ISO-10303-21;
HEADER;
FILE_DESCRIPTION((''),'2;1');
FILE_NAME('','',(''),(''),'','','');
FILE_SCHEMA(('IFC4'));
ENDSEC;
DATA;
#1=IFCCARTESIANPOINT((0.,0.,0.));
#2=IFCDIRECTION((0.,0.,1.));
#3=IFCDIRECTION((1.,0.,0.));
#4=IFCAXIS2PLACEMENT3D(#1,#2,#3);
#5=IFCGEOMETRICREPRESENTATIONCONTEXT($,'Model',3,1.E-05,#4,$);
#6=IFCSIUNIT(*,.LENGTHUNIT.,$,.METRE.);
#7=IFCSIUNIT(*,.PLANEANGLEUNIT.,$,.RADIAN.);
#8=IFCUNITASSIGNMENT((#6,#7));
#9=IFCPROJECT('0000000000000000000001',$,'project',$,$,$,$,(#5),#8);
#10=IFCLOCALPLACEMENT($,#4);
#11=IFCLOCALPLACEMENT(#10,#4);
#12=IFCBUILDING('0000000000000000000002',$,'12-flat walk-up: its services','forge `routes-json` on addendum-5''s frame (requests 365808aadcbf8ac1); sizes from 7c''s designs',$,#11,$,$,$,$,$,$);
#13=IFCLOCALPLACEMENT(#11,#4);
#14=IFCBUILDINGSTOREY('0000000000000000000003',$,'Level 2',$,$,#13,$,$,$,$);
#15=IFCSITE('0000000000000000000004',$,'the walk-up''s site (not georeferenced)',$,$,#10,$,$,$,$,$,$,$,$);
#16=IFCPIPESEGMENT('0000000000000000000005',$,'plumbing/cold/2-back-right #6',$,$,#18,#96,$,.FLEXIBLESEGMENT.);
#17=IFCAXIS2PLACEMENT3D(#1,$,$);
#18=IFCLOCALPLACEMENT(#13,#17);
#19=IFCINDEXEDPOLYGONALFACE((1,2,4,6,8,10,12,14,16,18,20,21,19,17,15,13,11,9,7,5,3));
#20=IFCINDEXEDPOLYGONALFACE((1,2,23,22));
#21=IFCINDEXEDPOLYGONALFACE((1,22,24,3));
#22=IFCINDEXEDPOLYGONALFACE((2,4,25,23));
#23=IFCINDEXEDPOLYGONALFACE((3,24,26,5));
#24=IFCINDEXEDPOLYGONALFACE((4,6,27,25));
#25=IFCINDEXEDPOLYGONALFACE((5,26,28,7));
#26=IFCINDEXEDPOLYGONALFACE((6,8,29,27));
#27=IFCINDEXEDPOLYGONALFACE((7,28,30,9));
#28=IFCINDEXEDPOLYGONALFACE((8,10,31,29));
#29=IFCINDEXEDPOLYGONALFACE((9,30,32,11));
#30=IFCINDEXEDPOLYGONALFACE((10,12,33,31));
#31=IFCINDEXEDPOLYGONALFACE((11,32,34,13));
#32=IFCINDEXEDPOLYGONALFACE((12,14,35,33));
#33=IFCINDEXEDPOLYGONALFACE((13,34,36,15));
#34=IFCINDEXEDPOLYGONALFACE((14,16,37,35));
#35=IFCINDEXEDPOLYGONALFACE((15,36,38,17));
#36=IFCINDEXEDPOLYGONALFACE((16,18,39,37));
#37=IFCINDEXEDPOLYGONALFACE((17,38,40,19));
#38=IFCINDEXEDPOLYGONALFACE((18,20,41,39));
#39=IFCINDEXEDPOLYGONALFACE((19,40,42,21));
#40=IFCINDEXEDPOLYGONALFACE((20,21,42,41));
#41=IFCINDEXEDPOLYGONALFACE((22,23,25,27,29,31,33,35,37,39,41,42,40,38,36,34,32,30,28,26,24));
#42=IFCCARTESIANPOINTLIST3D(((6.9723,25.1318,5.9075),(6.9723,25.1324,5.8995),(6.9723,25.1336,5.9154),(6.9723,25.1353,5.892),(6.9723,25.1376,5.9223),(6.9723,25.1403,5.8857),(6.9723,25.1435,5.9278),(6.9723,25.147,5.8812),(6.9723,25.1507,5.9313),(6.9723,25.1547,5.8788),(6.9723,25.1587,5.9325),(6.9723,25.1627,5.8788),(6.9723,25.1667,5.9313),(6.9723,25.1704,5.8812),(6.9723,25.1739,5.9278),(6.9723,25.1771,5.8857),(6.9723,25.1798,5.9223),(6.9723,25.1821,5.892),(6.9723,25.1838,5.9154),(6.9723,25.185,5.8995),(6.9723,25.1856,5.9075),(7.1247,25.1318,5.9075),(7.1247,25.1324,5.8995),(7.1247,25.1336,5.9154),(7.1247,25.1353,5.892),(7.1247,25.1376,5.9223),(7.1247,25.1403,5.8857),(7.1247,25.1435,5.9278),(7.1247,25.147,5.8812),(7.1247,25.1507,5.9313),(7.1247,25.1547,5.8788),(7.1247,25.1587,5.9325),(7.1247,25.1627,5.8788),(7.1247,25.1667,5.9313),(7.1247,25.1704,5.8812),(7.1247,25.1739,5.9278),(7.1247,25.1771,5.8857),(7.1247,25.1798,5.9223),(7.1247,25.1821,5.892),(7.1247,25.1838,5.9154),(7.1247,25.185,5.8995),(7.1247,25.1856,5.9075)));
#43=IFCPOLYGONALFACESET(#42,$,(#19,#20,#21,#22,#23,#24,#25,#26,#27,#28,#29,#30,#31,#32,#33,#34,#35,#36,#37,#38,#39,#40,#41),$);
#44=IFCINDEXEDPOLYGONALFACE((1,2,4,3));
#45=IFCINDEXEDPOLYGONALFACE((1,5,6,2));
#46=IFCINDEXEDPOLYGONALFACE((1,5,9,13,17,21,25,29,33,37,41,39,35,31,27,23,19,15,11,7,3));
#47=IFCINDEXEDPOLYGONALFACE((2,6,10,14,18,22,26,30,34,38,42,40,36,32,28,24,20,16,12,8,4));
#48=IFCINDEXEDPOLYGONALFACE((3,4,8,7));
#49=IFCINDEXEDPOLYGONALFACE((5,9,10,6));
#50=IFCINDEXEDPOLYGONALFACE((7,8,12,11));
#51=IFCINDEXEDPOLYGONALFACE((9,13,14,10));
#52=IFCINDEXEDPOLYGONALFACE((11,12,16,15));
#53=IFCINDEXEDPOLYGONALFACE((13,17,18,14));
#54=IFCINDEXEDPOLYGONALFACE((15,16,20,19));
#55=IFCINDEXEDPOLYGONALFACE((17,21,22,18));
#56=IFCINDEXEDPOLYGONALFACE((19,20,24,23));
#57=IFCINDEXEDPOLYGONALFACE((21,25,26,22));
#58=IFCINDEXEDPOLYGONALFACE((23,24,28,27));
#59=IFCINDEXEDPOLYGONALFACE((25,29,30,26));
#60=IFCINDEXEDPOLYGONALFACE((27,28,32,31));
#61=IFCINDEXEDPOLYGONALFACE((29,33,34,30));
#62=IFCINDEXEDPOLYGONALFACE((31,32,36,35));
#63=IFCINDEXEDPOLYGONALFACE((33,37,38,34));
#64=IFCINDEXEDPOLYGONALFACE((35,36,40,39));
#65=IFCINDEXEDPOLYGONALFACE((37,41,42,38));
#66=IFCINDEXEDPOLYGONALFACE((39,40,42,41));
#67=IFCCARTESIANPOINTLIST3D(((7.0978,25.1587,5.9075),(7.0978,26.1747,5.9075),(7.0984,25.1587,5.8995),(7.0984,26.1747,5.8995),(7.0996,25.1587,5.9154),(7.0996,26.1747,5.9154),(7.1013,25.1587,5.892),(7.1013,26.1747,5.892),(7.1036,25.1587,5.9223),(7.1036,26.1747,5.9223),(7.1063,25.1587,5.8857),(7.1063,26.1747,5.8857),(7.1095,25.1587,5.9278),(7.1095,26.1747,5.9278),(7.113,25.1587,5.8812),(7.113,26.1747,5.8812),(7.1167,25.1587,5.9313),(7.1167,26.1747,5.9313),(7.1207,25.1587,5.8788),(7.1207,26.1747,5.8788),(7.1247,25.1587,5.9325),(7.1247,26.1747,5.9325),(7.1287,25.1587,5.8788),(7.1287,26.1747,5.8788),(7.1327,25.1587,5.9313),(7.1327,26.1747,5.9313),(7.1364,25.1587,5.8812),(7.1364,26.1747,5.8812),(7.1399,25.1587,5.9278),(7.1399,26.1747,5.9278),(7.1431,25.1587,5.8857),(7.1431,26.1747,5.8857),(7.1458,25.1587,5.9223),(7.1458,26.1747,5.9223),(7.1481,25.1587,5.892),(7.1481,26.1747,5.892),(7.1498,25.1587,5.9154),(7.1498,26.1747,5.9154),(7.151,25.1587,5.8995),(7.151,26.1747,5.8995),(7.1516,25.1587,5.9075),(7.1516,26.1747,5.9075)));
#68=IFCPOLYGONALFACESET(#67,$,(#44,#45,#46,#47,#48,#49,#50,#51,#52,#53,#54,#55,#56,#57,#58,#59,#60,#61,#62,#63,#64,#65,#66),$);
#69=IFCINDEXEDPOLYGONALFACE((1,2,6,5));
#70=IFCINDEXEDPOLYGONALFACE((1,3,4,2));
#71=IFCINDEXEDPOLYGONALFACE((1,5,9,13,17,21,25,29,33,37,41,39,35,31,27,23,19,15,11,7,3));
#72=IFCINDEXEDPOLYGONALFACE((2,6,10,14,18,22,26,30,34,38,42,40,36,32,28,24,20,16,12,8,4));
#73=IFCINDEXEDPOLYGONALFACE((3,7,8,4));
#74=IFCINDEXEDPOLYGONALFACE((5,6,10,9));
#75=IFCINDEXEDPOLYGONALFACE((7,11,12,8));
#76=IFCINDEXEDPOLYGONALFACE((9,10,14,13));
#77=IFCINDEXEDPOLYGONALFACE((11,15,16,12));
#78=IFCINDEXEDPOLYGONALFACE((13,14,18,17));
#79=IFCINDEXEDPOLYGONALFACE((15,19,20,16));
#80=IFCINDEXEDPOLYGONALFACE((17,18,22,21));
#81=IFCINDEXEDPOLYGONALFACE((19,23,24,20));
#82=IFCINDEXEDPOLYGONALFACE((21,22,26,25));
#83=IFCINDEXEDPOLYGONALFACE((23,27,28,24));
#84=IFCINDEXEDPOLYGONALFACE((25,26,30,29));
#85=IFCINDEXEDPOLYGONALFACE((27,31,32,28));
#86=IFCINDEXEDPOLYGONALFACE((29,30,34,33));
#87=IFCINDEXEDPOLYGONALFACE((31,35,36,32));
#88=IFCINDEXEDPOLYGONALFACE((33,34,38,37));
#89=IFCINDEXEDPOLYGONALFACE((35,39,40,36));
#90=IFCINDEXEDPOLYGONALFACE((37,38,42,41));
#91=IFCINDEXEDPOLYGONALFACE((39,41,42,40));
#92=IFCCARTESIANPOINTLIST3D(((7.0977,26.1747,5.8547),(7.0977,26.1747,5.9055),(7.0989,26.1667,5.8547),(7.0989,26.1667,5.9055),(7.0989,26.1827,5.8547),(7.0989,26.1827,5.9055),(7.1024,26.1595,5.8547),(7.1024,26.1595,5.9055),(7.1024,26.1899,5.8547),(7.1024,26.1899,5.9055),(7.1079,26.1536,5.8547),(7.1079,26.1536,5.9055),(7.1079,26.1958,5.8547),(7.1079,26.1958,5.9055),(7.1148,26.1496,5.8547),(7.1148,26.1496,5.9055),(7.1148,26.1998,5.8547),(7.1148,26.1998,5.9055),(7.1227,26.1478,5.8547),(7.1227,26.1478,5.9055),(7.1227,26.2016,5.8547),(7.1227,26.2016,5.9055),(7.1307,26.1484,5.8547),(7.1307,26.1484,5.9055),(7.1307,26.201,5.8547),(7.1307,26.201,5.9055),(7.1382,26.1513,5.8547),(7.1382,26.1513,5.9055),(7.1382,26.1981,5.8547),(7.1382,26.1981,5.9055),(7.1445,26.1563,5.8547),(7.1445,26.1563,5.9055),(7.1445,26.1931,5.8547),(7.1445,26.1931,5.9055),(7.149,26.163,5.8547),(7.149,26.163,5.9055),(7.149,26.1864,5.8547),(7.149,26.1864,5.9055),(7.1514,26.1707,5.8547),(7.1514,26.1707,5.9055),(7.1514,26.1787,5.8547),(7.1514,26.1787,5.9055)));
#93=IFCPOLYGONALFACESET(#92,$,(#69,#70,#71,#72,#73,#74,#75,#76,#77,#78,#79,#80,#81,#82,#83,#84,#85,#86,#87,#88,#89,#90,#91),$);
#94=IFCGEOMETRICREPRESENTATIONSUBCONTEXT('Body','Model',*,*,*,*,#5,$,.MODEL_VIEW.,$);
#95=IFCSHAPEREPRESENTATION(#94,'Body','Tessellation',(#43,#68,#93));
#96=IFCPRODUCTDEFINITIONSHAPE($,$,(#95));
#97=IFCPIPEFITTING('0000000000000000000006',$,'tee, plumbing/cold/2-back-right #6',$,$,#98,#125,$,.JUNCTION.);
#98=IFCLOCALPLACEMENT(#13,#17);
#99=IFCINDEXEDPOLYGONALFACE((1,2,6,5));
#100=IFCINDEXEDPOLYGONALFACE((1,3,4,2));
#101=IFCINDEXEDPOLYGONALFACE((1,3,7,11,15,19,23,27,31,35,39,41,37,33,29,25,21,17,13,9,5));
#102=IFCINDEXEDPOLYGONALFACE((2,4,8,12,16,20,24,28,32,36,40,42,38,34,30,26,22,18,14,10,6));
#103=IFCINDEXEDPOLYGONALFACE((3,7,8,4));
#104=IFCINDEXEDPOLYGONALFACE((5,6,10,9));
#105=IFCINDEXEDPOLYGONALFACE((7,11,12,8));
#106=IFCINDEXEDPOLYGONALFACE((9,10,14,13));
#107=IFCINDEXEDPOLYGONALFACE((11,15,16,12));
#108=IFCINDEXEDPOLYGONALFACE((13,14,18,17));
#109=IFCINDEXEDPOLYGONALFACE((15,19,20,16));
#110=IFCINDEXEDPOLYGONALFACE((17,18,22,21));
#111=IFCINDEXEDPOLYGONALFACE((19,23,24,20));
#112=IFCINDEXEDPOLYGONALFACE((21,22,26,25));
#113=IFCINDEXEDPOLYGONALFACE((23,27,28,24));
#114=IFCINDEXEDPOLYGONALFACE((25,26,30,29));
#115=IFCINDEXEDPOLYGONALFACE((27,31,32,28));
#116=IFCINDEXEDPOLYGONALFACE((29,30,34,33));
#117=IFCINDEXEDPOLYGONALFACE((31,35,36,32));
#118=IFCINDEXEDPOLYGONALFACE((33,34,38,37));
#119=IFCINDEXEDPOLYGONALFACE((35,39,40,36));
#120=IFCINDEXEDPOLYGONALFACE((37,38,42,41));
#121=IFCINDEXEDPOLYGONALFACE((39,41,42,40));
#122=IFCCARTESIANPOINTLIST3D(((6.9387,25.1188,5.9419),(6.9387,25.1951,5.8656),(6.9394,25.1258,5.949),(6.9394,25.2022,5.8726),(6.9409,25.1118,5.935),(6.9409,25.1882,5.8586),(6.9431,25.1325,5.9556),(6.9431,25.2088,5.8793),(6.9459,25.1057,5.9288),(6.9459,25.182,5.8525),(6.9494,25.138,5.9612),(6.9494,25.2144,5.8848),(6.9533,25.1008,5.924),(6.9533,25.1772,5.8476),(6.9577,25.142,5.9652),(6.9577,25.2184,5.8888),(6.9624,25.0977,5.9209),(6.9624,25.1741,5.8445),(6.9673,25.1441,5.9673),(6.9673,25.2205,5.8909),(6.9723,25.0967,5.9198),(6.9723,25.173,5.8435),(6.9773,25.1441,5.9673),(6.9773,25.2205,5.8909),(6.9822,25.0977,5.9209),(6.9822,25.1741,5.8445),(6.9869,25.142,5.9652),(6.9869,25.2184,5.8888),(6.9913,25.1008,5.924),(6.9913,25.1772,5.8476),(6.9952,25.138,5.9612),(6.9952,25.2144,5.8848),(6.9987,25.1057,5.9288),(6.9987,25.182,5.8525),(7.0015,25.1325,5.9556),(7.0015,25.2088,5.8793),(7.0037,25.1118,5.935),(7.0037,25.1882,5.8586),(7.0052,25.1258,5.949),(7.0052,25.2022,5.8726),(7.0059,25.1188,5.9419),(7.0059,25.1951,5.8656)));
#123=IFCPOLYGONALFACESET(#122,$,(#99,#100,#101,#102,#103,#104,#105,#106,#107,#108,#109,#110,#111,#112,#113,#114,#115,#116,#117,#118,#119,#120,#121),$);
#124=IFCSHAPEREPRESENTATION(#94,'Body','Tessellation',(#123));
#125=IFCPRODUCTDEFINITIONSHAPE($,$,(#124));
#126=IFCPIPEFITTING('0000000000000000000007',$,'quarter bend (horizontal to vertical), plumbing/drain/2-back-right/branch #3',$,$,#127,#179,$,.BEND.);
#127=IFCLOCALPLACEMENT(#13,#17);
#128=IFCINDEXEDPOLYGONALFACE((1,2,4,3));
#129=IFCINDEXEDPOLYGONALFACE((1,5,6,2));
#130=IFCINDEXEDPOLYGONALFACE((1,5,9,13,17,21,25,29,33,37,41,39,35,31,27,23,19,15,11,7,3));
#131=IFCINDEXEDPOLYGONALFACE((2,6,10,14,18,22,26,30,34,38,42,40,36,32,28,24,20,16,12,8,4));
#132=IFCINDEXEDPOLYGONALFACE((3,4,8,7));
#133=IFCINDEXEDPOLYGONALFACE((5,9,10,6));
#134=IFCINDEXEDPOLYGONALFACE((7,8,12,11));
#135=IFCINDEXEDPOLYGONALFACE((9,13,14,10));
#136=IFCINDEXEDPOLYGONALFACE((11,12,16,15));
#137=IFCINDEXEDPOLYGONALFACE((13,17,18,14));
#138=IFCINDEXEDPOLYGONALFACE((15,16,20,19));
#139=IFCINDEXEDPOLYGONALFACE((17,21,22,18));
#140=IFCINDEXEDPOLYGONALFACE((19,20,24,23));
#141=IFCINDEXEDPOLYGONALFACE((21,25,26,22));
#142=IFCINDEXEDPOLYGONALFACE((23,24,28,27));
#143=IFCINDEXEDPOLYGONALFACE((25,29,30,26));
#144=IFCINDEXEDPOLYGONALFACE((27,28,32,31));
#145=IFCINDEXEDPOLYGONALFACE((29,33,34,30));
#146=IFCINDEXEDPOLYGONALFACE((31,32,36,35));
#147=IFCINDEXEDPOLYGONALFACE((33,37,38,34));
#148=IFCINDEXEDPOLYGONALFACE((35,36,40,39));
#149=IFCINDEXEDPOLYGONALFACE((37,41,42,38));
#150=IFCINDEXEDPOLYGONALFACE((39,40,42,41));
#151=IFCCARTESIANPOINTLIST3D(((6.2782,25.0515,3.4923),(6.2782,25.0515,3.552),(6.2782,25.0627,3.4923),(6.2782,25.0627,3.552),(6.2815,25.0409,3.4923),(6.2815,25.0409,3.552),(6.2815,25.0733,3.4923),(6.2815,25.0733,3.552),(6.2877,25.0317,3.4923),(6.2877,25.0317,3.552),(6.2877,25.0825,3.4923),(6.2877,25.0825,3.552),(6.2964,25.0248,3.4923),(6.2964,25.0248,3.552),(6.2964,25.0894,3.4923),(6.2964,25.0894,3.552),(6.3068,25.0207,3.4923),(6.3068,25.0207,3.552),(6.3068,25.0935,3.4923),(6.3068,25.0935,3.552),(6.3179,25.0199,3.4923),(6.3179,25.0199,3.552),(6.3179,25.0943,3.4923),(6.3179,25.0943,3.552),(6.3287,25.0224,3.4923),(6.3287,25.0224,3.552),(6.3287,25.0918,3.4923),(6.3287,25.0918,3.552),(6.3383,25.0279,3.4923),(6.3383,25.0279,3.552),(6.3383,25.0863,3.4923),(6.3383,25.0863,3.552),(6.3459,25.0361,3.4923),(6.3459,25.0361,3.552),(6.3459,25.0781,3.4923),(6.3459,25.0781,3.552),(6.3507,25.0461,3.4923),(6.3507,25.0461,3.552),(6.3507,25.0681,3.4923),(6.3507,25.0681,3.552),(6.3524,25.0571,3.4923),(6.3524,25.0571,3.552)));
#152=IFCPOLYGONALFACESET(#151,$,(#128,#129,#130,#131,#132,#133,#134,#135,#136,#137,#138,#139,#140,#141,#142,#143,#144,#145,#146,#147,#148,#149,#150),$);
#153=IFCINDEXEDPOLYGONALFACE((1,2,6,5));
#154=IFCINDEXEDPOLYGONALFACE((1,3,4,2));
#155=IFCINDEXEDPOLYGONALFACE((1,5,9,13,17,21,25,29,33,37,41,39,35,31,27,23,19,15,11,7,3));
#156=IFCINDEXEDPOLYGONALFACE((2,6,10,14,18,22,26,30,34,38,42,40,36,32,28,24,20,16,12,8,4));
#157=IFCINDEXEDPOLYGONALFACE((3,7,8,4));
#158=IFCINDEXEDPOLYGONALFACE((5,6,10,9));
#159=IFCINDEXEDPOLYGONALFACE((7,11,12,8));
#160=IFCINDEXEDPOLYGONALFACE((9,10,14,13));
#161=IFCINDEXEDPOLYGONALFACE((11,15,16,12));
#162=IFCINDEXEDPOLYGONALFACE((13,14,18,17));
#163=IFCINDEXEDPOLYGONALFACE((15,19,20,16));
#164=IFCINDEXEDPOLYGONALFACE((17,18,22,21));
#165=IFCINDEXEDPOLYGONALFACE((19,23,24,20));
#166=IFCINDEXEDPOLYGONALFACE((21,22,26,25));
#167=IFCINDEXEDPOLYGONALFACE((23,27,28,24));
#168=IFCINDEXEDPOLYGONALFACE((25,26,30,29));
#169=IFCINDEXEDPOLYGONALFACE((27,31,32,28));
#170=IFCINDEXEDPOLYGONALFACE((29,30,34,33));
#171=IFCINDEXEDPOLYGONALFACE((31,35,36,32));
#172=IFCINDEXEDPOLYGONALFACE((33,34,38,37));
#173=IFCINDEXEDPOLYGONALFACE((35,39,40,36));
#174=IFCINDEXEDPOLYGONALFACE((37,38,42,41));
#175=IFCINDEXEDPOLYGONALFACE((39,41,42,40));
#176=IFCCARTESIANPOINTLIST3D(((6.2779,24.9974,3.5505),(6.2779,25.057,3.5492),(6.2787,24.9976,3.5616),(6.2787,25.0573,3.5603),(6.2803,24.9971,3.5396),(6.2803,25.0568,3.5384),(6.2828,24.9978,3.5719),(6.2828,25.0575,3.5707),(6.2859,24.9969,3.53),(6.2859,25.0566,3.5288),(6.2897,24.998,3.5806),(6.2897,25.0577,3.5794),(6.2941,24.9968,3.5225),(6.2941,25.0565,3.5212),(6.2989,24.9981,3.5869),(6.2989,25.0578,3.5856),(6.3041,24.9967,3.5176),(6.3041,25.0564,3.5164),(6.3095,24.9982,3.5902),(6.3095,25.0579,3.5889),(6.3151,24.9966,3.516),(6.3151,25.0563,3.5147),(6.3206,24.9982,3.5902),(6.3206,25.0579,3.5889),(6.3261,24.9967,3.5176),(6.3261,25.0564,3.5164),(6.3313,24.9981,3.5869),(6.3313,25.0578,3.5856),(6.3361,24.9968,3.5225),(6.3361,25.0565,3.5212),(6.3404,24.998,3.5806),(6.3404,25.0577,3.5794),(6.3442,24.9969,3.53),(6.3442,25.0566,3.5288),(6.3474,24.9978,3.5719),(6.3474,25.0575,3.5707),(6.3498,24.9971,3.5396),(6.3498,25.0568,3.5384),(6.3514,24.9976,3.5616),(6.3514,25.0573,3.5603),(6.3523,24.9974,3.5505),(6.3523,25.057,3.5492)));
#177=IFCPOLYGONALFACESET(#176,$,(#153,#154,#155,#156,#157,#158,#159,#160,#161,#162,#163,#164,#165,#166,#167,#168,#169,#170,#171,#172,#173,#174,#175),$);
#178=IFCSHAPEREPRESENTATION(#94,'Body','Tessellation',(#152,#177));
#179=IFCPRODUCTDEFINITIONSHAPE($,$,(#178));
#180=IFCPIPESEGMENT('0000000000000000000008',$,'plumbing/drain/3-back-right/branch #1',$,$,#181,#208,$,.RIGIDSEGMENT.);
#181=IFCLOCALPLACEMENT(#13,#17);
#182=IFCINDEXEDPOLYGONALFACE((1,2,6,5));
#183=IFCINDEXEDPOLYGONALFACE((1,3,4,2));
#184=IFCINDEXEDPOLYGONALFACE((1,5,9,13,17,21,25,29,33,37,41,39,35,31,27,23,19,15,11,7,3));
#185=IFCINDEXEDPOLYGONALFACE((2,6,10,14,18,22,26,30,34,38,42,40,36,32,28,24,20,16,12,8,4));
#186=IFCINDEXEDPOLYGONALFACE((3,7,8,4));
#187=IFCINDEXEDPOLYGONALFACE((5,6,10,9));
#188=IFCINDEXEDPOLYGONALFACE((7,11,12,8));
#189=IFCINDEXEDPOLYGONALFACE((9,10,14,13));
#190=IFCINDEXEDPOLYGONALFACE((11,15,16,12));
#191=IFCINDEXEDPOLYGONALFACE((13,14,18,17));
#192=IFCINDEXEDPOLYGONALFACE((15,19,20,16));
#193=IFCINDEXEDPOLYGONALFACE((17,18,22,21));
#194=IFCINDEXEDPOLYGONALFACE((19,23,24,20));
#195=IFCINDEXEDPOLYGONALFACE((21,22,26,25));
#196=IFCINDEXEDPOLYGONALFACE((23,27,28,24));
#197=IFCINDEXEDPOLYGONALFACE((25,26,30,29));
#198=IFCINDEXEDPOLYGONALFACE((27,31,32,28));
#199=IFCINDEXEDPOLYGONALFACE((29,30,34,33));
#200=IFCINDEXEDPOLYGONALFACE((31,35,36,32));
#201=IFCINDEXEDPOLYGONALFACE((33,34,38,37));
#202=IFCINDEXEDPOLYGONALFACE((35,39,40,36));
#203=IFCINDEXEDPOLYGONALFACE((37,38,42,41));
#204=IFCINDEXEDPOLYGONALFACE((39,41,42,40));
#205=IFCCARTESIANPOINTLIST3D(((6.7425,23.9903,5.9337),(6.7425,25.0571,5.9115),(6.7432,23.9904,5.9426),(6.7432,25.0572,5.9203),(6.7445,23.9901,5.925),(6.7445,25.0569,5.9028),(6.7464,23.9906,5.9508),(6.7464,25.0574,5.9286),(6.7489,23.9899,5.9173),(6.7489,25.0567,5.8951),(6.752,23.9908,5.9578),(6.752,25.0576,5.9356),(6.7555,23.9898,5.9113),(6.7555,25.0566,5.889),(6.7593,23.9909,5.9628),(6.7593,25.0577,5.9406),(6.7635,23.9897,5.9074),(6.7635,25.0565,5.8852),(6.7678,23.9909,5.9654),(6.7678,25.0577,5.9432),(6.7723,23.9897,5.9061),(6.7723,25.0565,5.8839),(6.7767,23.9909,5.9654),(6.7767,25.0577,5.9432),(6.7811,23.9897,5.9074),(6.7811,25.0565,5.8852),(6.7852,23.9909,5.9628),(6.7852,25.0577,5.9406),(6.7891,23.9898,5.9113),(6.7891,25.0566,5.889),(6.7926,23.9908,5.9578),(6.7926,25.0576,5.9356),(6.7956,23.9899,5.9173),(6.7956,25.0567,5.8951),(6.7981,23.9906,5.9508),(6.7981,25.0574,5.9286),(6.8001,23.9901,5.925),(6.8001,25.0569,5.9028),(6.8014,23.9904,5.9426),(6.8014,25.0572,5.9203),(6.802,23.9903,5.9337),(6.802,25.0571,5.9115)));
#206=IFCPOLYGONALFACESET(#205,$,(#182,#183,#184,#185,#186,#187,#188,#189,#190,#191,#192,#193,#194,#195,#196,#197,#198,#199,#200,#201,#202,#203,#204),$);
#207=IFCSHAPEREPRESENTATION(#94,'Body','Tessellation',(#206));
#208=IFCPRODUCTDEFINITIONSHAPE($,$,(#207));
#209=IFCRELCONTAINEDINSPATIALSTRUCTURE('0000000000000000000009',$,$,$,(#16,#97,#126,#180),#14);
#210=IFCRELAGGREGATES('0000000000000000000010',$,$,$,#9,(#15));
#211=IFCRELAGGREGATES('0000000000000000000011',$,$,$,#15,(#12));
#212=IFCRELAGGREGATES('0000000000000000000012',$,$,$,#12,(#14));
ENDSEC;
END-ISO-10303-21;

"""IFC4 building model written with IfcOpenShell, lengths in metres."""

from ifc_helpers import new_model, entity, si_unit, frame, origin_with_axes, place, context, subcontext, project, spatial, element, save


model = new_model("IFC4")

# Units and contexts
model_context = context("Model", 3, precision=1e-05, world=origin_with_axes())
body_context = subcontext(model_context, "Body", "Model", "MODEL_VIEW")
ifc_project = project(units=[si_unit("LENGTHUNIT", "METRE"), si_unit("PLANEANGLEUNIT", "RADIAN")], contexts=[model_context])

# Site, building, storey
site_placement = place(None, origin_with_axes())
site = spatial("IfcSite", under=ifc_project, at=site_placement, Name="the walk-up's site (not georeferenced)")
building_placement = place(site_placement, origin_with_axes())
building = spatial("IfcBuilding", under=site, at=building_placement, Name="12-flat walk-up: its services", Description="forge `routes-json` on addendum-5's frame (requests 365808aadcbf8ac1); sizes from 7c's designs")
storey_placement = place(building_placement, origin_with_axes())
storey = spatial("IfcBuildingStorey", under=building, at=storey_placement, Name="Level 2")

# Pipe segment
pipe_segment_1_placement = place(storey_placement, frame((6.9723, 25.1587, 5.9055), z_axis=(0.0, 0.0, 1.0), x_axis=(1.0, 0.0, 0.0)))
element("IfcPipeSegment", 1, at=pipe_segment_1_placement, inside=storey, Name="plumbing/cold/2-back-right #6", PredefinedType="FLEXIBLESEGMENT", context=body_context, shape_type="AdvancedSweptSolid", body=[
    entity("IfcSweptDiskSolid", entity("IfcPolyline", [entity("IfcCartesianPoint", [0.0, 0.0, 0.0]), entity("IfcCartesianPoint", [0.1524, 0.0, 0.0])]), 0.027),
    entity("IfcSweptDiskSolid", entity("IfcPolyline", [entity("IfcCartesianPoint", [0.1524, 0.0, 0.0]), entity("IfcCartesianPoint", [0.1524, 1.016, 0.0])]), 0.027),
    entity("IfcSweptDiskSolid", entity("IfcPolyline", [entity("IfcCartesianPoint", [0.1524, 1.016, 0.0]), entity("IfcCartesianPoint", [0.1524, 1.016, -0.0508])]), 0.027),
])

# Pipe fittings
pipe_fitting_1_placement = place(storey_placement, frame((6.9723, 25.1205, 5.9437), z_axis=(0.0, 0.0, 1.0), x_axis=(1.0, 0.0, 0.0)))
element("IfcPipeFitting", 2, at=pipe_fitting_1_placement, inside=storey, Name="tee, plumbing/cold/2-back-right #6", PredefinedType="JUNCTION", context=body_context, shape_type="AdvancedSweptSolid", body=[
    entity("IfcSweptDiskSolid", entity("IfcPolyline", [entity("IfcCartesianPoint", [0.0, 0.0, 0.0]), entity("IfcCartesianPoint", [0.0, 0.0763, -0.0763])]), 0.0337),
])
pipe_fitting_2_placement = place(storey_placement, frame((6.3151, 25.0571, 3.4923), z_axis=(0.0, 0.0, 1.0), x_axis=(1.0, 0.0, 0.0)))
element("IfcPipeFitting", 3, at=pipe_fitting_2_placement, inside=storey, Name="quarter bend (horizontal to vertical), plumbing/drain/2-back-right/branch #3", PredefinedType="BEND", context=body_context, shape_type="AdvancedSweptSolid", body=[
    entity("IfcSweptDiskSolid", entity("IfcPolyline", [entity("IfcCartesianPoint", [0.0, 0.0, 0.0]), entity("IfcCartesianPoint", [0.0, 0.0, 0.0597])]), 0.0373),
    entity("IfcSweptDiskSolid", entity("IfcPolyline", [entity("IfcCartesianPoint", [0.0, 0.0, 0.0597]), entity("IfcCartesianPoint", [0.0, -0.0597, 0.0609])]), 0.0373),
])

# Pipe segment
pipe_segment_2_placement = place(storey_placement, frame((6.7723, 25.0571, 5.9137), z_axis=(0.0, 0.0, 1.0), x_axis=(1.0, 0.0, 0.0)))
element("IfcPipeSegment", 4, at=pipe_segment_2_placement, inside=storey, Name="plumbing/drain/3-back-right/branch #1", PredefinedType="RIGIDSEGMENT", context=body_context, shape_type="AdvancedSweptSolid", body=[
    entity("IfcSweptDiskSolid", entity("IfcPolyline", [entity("IfcCartesianPoint", [0.0, 0.0, 0.0]), entity("IfcCartesianPoint", [0.0, -1.0668, 0.0222])]), 0.0298),
])

save(model, "model.ifc")
